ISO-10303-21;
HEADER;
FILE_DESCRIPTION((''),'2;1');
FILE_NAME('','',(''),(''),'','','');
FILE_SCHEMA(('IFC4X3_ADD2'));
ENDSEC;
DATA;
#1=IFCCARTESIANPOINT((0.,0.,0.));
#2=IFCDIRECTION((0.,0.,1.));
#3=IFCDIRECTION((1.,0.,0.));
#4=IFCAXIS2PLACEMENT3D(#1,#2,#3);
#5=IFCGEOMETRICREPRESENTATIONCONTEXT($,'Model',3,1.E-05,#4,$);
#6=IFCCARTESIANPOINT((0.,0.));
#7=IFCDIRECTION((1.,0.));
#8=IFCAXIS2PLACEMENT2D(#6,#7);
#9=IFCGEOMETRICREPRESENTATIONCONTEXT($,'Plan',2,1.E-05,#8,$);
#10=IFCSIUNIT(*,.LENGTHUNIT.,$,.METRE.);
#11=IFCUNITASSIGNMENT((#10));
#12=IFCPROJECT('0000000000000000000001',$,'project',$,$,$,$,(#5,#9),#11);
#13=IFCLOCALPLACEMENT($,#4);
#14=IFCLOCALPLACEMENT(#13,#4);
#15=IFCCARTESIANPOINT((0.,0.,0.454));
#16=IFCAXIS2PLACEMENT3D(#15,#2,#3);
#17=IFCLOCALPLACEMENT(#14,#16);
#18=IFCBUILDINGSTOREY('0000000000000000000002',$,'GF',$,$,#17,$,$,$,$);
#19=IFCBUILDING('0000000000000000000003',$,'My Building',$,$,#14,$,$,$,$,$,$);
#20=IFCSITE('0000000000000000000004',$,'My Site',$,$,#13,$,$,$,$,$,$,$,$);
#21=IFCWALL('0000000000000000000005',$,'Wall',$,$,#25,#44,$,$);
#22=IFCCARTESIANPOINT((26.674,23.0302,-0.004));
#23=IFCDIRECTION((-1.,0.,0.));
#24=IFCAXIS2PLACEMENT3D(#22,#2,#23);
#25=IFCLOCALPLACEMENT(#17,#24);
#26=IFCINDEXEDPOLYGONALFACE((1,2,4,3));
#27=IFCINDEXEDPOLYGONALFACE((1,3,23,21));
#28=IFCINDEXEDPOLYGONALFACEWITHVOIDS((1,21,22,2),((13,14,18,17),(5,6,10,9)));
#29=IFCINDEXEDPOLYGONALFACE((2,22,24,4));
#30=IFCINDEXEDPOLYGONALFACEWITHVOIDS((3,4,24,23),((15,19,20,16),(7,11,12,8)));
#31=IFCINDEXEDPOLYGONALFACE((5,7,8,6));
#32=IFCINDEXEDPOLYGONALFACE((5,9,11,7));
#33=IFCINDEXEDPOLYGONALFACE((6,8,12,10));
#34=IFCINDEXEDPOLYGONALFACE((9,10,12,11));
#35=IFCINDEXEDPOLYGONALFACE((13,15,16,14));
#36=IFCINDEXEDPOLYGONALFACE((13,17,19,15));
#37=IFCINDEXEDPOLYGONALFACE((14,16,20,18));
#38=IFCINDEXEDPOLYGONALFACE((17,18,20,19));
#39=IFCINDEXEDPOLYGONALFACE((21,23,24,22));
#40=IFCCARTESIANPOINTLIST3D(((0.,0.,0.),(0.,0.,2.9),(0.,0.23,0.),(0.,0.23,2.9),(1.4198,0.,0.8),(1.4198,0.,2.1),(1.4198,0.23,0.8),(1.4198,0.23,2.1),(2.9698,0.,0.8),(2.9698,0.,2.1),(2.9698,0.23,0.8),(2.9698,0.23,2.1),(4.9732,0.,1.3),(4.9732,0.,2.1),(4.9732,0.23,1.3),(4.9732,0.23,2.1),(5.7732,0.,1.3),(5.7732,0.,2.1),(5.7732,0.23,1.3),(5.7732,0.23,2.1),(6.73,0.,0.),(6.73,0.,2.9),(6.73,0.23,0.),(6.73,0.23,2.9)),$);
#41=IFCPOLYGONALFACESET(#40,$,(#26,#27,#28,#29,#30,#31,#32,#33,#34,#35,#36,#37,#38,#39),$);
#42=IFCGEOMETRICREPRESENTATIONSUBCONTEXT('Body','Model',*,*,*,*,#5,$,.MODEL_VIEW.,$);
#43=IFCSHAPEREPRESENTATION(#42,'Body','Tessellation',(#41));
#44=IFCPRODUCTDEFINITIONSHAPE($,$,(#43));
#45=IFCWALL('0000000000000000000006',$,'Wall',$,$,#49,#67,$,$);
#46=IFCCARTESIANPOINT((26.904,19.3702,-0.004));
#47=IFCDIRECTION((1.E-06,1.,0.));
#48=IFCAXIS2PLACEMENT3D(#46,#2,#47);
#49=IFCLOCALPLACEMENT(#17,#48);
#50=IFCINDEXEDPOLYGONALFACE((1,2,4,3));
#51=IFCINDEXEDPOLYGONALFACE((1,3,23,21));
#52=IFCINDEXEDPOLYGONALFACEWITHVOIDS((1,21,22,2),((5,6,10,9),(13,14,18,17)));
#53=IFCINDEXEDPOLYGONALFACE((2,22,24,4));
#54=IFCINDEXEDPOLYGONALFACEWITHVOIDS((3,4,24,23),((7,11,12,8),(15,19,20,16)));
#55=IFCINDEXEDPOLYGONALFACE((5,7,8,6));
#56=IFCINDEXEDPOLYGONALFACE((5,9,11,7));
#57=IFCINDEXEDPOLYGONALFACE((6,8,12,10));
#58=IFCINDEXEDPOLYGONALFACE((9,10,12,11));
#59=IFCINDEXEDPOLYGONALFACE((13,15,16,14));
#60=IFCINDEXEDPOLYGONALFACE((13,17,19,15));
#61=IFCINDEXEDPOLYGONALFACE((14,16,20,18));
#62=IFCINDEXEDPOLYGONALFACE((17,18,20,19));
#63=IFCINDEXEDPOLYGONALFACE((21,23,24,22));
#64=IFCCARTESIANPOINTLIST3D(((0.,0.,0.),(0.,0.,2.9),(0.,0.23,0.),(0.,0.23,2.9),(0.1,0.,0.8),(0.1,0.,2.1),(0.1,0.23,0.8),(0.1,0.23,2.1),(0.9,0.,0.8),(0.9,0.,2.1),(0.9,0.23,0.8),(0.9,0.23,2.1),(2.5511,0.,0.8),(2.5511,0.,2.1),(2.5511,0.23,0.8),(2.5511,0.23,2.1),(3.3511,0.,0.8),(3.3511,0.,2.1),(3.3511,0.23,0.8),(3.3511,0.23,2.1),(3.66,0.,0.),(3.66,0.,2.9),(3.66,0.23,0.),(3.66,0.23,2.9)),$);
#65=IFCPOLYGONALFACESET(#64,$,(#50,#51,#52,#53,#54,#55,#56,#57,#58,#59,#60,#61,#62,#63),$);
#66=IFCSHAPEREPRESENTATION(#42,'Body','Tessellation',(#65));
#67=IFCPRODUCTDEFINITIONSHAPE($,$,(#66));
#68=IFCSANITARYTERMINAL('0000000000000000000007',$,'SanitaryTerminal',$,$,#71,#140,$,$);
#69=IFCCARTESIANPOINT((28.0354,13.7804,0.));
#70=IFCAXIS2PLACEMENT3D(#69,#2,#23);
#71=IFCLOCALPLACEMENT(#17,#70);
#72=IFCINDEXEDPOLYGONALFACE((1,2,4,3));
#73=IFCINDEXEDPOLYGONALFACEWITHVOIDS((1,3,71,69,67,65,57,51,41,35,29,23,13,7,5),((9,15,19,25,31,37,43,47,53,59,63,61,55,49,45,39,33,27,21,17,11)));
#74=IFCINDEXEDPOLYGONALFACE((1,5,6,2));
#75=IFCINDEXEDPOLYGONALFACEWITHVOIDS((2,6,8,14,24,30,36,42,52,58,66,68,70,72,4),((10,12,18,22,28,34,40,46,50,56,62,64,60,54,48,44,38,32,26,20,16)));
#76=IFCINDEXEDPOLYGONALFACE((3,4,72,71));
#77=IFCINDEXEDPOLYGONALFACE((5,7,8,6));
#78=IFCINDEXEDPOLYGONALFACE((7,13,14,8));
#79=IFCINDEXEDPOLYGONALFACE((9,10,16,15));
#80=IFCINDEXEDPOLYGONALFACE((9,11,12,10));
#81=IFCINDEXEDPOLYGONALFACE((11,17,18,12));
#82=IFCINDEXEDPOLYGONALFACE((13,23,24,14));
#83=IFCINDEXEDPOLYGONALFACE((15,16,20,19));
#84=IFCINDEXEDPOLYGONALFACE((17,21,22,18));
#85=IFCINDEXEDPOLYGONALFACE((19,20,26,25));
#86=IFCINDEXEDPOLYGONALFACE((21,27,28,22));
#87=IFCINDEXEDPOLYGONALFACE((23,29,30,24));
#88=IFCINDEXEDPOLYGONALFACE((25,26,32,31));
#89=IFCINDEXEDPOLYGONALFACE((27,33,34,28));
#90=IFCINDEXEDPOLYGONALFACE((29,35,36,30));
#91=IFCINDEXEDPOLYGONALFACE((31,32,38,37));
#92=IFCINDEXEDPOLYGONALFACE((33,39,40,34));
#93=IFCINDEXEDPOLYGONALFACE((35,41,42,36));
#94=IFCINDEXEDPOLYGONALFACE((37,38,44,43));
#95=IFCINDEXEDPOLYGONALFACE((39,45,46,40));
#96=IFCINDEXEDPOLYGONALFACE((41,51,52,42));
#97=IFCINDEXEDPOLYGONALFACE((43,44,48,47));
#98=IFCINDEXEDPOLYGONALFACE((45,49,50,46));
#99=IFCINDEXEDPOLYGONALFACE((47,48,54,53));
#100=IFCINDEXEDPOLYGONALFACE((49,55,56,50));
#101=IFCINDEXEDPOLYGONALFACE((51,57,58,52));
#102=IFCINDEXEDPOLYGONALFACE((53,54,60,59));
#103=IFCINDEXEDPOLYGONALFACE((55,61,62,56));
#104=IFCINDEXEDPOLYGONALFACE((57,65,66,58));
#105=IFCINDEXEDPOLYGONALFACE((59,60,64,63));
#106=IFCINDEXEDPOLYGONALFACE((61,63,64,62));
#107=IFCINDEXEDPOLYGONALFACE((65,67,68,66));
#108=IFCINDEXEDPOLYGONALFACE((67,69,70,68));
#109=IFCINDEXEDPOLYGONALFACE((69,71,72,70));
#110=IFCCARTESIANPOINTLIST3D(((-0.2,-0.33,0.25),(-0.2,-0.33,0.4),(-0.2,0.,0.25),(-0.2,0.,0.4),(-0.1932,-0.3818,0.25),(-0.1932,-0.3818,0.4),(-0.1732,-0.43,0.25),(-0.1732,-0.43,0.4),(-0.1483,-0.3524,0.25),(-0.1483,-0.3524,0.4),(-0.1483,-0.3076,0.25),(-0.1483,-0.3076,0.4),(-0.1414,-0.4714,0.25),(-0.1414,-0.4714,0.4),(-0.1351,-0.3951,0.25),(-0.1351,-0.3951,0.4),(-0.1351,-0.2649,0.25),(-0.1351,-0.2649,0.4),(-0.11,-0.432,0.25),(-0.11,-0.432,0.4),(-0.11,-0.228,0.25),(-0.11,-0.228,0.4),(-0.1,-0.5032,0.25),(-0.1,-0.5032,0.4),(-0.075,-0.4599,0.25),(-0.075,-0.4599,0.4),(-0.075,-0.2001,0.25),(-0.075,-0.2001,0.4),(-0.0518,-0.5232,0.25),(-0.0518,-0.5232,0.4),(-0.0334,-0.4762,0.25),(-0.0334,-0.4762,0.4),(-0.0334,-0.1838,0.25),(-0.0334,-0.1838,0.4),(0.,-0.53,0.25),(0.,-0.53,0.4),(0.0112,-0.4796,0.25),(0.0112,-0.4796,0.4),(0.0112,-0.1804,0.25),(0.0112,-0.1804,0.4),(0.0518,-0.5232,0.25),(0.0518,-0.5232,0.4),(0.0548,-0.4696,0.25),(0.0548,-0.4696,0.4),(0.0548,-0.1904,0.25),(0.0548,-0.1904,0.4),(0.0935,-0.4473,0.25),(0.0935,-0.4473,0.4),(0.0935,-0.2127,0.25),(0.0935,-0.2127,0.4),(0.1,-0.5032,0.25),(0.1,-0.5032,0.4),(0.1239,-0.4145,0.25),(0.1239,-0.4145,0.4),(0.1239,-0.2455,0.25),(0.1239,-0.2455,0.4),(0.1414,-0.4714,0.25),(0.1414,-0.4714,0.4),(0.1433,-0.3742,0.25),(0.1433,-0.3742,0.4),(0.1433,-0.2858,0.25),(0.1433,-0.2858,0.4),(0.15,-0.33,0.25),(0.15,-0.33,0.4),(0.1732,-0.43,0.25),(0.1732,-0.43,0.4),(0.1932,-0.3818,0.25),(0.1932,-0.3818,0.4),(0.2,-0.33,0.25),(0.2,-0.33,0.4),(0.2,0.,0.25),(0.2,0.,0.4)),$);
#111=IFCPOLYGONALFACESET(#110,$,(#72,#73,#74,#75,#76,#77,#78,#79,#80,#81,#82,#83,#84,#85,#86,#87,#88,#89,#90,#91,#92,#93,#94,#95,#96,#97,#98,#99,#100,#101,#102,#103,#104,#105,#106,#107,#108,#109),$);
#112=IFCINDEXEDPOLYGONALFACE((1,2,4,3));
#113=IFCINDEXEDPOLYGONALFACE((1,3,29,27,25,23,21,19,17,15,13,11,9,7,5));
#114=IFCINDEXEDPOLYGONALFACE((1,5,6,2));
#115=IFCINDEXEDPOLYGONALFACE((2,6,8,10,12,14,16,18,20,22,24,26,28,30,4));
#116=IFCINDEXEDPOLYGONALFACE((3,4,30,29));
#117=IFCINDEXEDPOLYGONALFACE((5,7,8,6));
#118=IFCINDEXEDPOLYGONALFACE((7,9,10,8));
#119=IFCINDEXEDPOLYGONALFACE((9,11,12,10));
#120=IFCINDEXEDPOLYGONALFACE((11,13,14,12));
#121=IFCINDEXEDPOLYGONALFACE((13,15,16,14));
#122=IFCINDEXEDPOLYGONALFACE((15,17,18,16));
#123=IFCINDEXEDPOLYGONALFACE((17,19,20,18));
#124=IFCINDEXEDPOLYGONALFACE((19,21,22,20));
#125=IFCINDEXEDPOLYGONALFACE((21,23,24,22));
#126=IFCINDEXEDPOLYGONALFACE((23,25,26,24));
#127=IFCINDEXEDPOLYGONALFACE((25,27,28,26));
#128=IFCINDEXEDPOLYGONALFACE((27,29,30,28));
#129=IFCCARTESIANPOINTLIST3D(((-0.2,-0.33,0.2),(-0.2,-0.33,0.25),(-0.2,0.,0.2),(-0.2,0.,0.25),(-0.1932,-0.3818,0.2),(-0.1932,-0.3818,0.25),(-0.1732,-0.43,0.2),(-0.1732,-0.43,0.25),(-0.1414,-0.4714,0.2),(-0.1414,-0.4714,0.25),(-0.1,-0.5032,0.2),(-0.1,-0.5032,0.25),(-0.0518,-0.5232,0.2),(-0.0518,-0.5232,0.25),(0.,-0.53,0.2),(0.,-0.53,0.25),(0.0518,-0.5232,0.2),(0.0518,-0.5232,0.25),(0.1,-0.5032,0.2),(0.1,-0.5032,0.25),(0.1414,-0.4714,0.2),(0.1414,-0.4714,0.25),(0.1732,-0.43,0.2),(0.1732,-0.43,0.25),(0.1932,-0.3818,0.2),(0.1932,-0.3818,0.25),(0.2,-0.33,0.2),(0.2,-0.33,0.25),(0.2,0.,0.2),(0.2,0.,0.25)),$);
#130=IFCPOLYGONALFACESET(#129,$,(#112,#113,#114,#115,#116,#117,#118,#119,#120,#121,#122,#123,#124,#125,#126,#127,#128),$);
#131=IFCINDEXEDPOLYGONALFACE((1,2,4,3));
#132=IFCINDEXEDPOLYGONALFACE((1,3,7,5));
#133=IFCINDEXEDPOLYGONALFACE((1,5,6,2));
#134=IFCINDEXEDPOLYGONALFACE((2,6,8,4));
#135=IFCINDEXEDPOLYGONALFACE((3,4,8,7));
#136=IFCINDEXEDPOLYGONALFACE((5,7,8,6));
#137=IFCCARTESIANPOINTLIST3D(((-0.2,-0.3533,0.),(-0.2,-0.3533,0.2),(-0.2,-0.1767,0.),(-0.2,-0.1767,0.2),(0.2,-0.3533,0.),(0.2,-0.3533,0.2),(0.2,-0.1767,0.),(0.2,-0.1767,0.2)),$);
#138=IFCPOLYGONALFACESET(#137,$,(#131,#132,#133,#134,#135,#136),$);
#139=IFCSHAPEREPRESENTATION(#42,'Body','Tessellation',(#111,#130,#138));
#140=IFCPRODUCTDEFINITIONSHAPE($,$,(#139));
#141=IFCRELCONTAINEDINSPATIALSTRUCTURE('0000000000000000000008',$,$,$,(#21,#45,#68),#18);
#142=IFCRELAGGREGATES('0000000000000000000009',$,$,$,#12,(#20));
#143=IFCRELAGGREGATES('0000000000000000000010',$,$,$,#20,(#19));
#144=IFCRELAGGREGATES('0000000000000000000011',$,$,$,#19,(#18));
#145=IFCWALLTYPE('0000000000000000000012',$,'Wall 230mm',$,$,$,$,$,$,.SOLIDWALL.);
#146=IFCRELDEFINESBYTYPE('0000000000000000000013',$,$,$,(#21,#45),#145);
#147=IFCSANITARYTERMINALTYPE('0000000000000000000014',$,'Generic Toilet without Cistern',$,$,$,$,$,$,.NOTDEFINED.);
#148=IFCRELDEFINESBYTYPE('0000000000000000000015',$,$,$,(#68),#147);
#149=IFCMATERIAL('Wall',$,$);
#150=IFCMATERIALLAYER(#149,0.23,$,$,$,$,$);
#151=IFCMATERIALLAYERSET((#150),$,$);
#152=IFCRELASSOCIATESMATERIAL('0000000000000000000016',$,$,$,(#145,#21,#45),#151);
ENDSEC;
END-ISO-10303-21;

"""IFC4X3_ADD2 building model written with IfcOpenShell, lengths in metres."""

from ifc_helpers import new_model, entity, si_unit, frame, frame_2d, origin_with_axes, origin_2d_with_axis, place, context, subcontext, project, spatial, line, arc, indexed_curve, circle_curve, outline, extrude, shape, source, transform, mapped, material, layer, layer_set, layer_usage, type_object, type_shapes, element, save


model = new_model("IFC4X3_ADD2")

# Units and contexts
model_context = context("Model", 3, precision=1e-05, world=origin_with_axes())
plan_context = context("Plan", 2, precision=1e-05, world=origin_2d_with_axis())
body_context_1 = subcontext(model_context, "Body", "Model", "MODEL_VIEW")
body_context_2 = subcontext(plan_context, "Body", "Plan", "PLAN_VIEW")
ifc_project = project(units=[si_unit("LENGTHUNIT", "METRE")], contexts=[model_context, plan_context])

# Site, building, storey
site_placement = place(None, origin_with_axes())
site = spatial("IfcSite", under=ifc_project, at=site_placement, Name="My Site")
building_placement = place(site_placement, origin_with_axes())
building = spatial("IfcBuilding", under=site, at=building_placement, Name="My Building")
storey_placement = place(building_placement, frame((0.0, 0.0, 0.454), z_axis=(0.0, 0.0, 1.0), x_axis=(1.0, 0.0, 0.0)))
storey = spatial("IfcBuildingStorey", under=building, at=storey_placement, Name="GF")

# Shared definitions
ifc_material_1 = material(Name="Wall")

# Wall, openings
ifc_layer_1 = layer(ifc_material_1, 0.23)
ifc_layer_set_1 = layer_set([ifc_layer_1])
ifc_layer_usage_1 = layer_usage(ifc_layer_set_1, "AXIS2", "POSITIVE", 0.0)
wall_type_1 = type_object("IfcWallType", Name="Wall 230mm", PredefinedType="SOLIDWALL", material=ifc_layer_set_1)
wall_1_placement = place(storey_placement, frame((26.674, 23.0302, -0.004), z_axis=(0.0, 0.0, 1.0), x_axis=(-1.0, 0.0, 0.0)))
wall_1 = element("IfcWall", 1, at=wall_1_placement, inside=storey, type_object=wall_type_1, material=ifc_layer_usage_1, Name="Wall", context=body_context_1, shape_type="SweptSolid", body=[
    extrude(outline(indexed_curve([(0.0, 0.0), (0.0, 0.23), (6.73, 0.23), (6.73, 0.0), (0.0, 0.0)], self_intersect=False)), origin_with_axes(), (0.0, 0.0, 1.0), 2.9),
])
shared_shape_1 = source(origin_with_axes(), body_context_1, "Body", "SweptSolid", [
    extrude(outline(indexed_curve([(0.0, 0.0), (0.8, 0.0), (0.8, 0.8), (0.0, 0.8)], segments=[line(1, 2, 3, 4, 1)])), frame((-0.4, -0.6, 0.0), z_axis=(0.0, -1.0, 0.0), x_axis=(1.0, 0.0, 0.0)), (0.0, 0.0, -1.0), 1.2),
])
opening_1_placement = place(wall_1_placement, frame((5.3732, 0.16, 1.3), z_axis=(0.0, 0.0, 1.0), x_axis=(1.0, 0.0, 0.0)))
element("IfcOpeningElement", 2, at=opening_1_placement, cuts=wall_1, PredefinedType="OPENING", context=body_context_1, shape_type="MappedRepresentation", body=[
    mapped(shared_shape_1, transform((0.0, 0.0, 0.0), x_axis=(1.0, 0.0, 0.0), y_axis=(0.0, 1.0, 0.0), z_axis=(0.0, 0.0, 1.0), scale=1.0)),
])
shared_shape_2 = source(origin_with_axes(), body_context_1, "Body", "SweptSolid", [
    extrude(outline(indexed_curve([(0.0, 0.0), (1.55, 0.0), (1.55, 1.3), (0.0, 1.3)], segments=[line(1, 2, 3, 4, 1)])), frame((-0.775, -0.6, 0.0), z_axis=(0.0, -1.0, 0.0), x_axis=(1.0, 0.0, 0.0)), (0.0, 0.0, -1.0), 1.2),
])
opening_2_placement = place(wall_1_placement, frame((2.1948, 0.16, 0.8), z_axis=(0.0, 0.0, 1.0), x_axis=(1.0, 0.0, 0.0)))
element("IfcOpeningElement", 3, at=opening_2_placement, cuts=wall_1, PredefinedType="OPENING", context=body_context_1, shape_type="MappedRepresentation", body=[
    mapped(shared_shape_2, transform((0.0, 0.0, 0.0), x_axis=(1.0, 0.0, 0.0), y_axis=(0.0, 1.0, 0.0), z_axis=(0.0, 0.0, 1.0), scale=1.0)),
])

# Wall, openings
ifc_layer_usage_2 = layer_usage(ifc_layer_set_1, "AXIS2", "POSITIVE", 0.0)
wall_2_placement = place(storey_placement, frame((26.904, 19.3702, -0.004), z_axis=(0.0, 0.0, 1.0), x_axis=(0.000001, 1.0, 0.0)))
wall_2 = element("IfcWall", 4, at=wall_2_placement, inside=storey, type_object=wall_type_1, material=ifc_layer_usage_2, Name="Wall", context=body_context_1, shape_type="SweptSolid", body=[
    extrude(outline(indexed_curve([(0.0, 0.0), (0.0, 0.23), (3.66, 0.23), (3.66, 0.0), (0.0, 0.0)], self_intersect=False)), origin_with_axes(), (0.0, 0.0, 1.0), 2.9),
])
shared_shape_3 = source(origin_with_axes(), body_context_1, "Body", "SweptSolid", [
    extrude(outline(indexed_curve([(0.0, 0.0), (0.8, 0.0), (0.8, 1.3), (0.0, 1.3)], segments=[line(1, 2, 3, 4, 1)])), frame((-0.4, -0.6, 0.0), z_axis=(0.0, -1.0, 0.0), x_axis=(1.0, 0.0, 0.0)), (0.0, 0.0, -1.0), 1.2),
])
opening_3_placement = place(wall_2_placement, frame((0.5, 0.16, 0.8), z_axis=(0.0, 0.0, 1.0), x_axis=(1.0, 0.0, 0.0)))
element("IfcOpeningElement", 5, at=opening_3_placement, cuts=wall_2, PredefinedType="OPENING", context=body_context_1, shape_type="MappedRepresentation", body=[
    mapped(shared_shape_3, transform((0.0, 0.0, 0.0), x_axis=(1.0, 0.0, 0.0), y_axis=(0.0, 1.0, 0.0), z_axis=(0.0, 0.0, 1.0), scale=1.0)),
])
opening_4_placement = place(wall_2_placement, frame((2.9511, 0.16, 0.8), z_axis=(0.0, 0.0, 1.0), x_axis=(1.0, 0.0, 0.0)))
element("IfcOpeningElement", 6, at=opening_4_placement, cuts=wall_2, PredefinedType="OPENING", context=body_context_1, shape_type="MappedRepresentation", body=[
    mapped(shared_shape_3, transform((0.0, 0.0, 0.0), x_axis=(1.0, 0.0, 0.0), y_axis=(0.0, 1.0, 0.0), z_axis=(0.0, 0.0, 1.0), scale=1.0)),
])

# Sanitary terminal
sanitary_terminal_type_1 = type_object("IfcSanitaryTerminalType", Name="Generic Toilet without Cistern", PredefinedType="NOTDEFINED")
shared_shape_4 = source(origin_with_axes(), body_context_1, "Body", "SweptSolid", [
    extrude(outline(indexed_curve([(-0.2, 0.0), (0.2, 0.0), (0.2, -0.33), (0.1414, -0.4714), (0.0, -0.53), (-0.1414, -0.4714), (-0.2, -0.33)], segments=[line(1, 2), line(2, 3), arc(3, 4, 5), arc(5, 6, 7), line(7, 1)]), holes=[circle_curve(frame_2d((0.0, -0.33)), 0.15)]), frame((0.0, 0.0, 0.25), z_axis=(0.0, 0.0, 1.0), x_axis=(1.0, 0.0, 0.0)), (0.0, 0.0, 1.0), 0.15),
    extrude(outline(indexed_curve([(-0.2, 0.0), (0.2, 0.0), (0.2, -0.33), (0.1414, -0.4714), (0.0, -0.53), (-0.1414, -0.4714), (-0.2, -0.33)], segments=[line(1, 2), line(2, 3), arc(3, 4, 5), arc(5, 6, 7), line(7, 1)])), frame((0.0, 0.0, 0.2), z_axis=(0.0, 0.0, 1.0), x_axis=(1.0, 0.0, 0.0)), (0.0, 0.0, 1.0), 0.05),
    extrude(outline(indexed_curve([(-0.2, -0.1767), (0.2, -0.1767), (0.2, -0.3533), (-0.2, -0.3533)], segments=[line(1, 2, 3, 4, 1)])), origin_with_axes(), (0.0, 0.0, 1.0), 0.2),
])
shared_shape_5 = source(origin_with_axes(), body_context_2, "Body", "Annotation2D", [
    entity("IfcGeometricCurveSet", [entity("IfcIndexedPolyCurve", entity("IfcCartesianPointList2D", [[-0.1068, -0.124], [-0.0957, -0.1129], [-0.0804, -0.1088], [0.0804, -0.1088], [0.0957, -0.1129], [0.1068, -0.124], [0.1109, -0.1393], [0.1109, -0.3476], [0.1025, -0.3926], [0.0784, -0.4308], [0.0424, -0.4563], [0.0, -0.4652], [-0.0424, -0.4563], [-0.0784, -0.4308], [-0.1025, -0.3926], [-0.1109, -0.3476], [-0.1109, -0.1393]]), [entity("IfcLineIndex", [1, 2, 3, 4, 5, 6, 7, 8, 9, 10, 11, 12, 13, 14, 15, 16, 17, 1])]), entity("IfcIndexedPolyCurve", entity("IfcCartesianPointList2D", [[-0.1962, -0.2314], [-0.1848, -0.301], [-0.1764, -0.3339], [-0.1663, -0.3651], [-0.1546, -0.3944], [-0.1414, -0.4213], [-0.1269, -0.4458], [-0.1111, -0.4675], [-0.0943, -0.4862], [-0.0765, -0.5018], [-0.0581, -0.514], [-0.039, -0.5229], [-0.0196, -0.5282], [0.0, -0.53], [0.0196, -0.5282], [0.039, -0.5229], [0.0581, -0.514], [0.0765, -0.5018], [0.0943, -0.4862], [0.1111, -0.4675], [0.1269, -0.4458], [0.1414, -0.4213], [0.1546, -0.3944], [0.1663, -0.3651], [0.1764, -0.3339], [0.1848, -0.301], [0.1962, -0.2314], [0.2, -0.159], [0.1872, 0.0], [-0.1872, 0.0], [-0.2, -0.159]]), [entity("IfcLineIndex", [1, 2, 3, 4, 5, 6, 7, 8, 9, 10, 11, 12, 13, 14, 15, 16, 17, 18, 19, 20, 21, 22, 23, 24, 25, 26, 27, 28, 29, 30, 31, 1])])]),
])
type_shapes(sanitary_terminal_type_1, [shared_shape_4, shared_shape_5])
sanitary_terminal_1_placement = place(storey_placement, frame((28.0354, 13.7804, 0.0), z_axis=(0.0, 0.0, 1.0), x_axis=(-1.0, 0.0, 0.0)))
element("IfcSanitaryTerminal", 7, at=sanitary_terminal_1_placement, inside=storey, type_object=sanitary_terminal_type_1, Name="SanitaryTerminal", shapes=[
    shape(body_context_1, "Body", "MappedRepresentation", [mapped(shared_shape_4, transform((0.0, 0.0, 0.0), x_axis=(1.0, 0.0, 0.0), y_axis=(0.0, 1.0, 0.0), z_axis=(0.0, 0.0, 1.0), scale=1.0))]),
    shape(body_context_2, "Body", "MappedRepresentation", [mapped(shared_shape_5, transform((0.0, 0.0, 0.0), x_axis=(1.0, 0.0, 0.0), y_axis=(0.0, 1.0, 0.0), z_axis=(0.0, 0.0, 1.0), scale=1.0))]),
])

save(model, "model.ifc")
